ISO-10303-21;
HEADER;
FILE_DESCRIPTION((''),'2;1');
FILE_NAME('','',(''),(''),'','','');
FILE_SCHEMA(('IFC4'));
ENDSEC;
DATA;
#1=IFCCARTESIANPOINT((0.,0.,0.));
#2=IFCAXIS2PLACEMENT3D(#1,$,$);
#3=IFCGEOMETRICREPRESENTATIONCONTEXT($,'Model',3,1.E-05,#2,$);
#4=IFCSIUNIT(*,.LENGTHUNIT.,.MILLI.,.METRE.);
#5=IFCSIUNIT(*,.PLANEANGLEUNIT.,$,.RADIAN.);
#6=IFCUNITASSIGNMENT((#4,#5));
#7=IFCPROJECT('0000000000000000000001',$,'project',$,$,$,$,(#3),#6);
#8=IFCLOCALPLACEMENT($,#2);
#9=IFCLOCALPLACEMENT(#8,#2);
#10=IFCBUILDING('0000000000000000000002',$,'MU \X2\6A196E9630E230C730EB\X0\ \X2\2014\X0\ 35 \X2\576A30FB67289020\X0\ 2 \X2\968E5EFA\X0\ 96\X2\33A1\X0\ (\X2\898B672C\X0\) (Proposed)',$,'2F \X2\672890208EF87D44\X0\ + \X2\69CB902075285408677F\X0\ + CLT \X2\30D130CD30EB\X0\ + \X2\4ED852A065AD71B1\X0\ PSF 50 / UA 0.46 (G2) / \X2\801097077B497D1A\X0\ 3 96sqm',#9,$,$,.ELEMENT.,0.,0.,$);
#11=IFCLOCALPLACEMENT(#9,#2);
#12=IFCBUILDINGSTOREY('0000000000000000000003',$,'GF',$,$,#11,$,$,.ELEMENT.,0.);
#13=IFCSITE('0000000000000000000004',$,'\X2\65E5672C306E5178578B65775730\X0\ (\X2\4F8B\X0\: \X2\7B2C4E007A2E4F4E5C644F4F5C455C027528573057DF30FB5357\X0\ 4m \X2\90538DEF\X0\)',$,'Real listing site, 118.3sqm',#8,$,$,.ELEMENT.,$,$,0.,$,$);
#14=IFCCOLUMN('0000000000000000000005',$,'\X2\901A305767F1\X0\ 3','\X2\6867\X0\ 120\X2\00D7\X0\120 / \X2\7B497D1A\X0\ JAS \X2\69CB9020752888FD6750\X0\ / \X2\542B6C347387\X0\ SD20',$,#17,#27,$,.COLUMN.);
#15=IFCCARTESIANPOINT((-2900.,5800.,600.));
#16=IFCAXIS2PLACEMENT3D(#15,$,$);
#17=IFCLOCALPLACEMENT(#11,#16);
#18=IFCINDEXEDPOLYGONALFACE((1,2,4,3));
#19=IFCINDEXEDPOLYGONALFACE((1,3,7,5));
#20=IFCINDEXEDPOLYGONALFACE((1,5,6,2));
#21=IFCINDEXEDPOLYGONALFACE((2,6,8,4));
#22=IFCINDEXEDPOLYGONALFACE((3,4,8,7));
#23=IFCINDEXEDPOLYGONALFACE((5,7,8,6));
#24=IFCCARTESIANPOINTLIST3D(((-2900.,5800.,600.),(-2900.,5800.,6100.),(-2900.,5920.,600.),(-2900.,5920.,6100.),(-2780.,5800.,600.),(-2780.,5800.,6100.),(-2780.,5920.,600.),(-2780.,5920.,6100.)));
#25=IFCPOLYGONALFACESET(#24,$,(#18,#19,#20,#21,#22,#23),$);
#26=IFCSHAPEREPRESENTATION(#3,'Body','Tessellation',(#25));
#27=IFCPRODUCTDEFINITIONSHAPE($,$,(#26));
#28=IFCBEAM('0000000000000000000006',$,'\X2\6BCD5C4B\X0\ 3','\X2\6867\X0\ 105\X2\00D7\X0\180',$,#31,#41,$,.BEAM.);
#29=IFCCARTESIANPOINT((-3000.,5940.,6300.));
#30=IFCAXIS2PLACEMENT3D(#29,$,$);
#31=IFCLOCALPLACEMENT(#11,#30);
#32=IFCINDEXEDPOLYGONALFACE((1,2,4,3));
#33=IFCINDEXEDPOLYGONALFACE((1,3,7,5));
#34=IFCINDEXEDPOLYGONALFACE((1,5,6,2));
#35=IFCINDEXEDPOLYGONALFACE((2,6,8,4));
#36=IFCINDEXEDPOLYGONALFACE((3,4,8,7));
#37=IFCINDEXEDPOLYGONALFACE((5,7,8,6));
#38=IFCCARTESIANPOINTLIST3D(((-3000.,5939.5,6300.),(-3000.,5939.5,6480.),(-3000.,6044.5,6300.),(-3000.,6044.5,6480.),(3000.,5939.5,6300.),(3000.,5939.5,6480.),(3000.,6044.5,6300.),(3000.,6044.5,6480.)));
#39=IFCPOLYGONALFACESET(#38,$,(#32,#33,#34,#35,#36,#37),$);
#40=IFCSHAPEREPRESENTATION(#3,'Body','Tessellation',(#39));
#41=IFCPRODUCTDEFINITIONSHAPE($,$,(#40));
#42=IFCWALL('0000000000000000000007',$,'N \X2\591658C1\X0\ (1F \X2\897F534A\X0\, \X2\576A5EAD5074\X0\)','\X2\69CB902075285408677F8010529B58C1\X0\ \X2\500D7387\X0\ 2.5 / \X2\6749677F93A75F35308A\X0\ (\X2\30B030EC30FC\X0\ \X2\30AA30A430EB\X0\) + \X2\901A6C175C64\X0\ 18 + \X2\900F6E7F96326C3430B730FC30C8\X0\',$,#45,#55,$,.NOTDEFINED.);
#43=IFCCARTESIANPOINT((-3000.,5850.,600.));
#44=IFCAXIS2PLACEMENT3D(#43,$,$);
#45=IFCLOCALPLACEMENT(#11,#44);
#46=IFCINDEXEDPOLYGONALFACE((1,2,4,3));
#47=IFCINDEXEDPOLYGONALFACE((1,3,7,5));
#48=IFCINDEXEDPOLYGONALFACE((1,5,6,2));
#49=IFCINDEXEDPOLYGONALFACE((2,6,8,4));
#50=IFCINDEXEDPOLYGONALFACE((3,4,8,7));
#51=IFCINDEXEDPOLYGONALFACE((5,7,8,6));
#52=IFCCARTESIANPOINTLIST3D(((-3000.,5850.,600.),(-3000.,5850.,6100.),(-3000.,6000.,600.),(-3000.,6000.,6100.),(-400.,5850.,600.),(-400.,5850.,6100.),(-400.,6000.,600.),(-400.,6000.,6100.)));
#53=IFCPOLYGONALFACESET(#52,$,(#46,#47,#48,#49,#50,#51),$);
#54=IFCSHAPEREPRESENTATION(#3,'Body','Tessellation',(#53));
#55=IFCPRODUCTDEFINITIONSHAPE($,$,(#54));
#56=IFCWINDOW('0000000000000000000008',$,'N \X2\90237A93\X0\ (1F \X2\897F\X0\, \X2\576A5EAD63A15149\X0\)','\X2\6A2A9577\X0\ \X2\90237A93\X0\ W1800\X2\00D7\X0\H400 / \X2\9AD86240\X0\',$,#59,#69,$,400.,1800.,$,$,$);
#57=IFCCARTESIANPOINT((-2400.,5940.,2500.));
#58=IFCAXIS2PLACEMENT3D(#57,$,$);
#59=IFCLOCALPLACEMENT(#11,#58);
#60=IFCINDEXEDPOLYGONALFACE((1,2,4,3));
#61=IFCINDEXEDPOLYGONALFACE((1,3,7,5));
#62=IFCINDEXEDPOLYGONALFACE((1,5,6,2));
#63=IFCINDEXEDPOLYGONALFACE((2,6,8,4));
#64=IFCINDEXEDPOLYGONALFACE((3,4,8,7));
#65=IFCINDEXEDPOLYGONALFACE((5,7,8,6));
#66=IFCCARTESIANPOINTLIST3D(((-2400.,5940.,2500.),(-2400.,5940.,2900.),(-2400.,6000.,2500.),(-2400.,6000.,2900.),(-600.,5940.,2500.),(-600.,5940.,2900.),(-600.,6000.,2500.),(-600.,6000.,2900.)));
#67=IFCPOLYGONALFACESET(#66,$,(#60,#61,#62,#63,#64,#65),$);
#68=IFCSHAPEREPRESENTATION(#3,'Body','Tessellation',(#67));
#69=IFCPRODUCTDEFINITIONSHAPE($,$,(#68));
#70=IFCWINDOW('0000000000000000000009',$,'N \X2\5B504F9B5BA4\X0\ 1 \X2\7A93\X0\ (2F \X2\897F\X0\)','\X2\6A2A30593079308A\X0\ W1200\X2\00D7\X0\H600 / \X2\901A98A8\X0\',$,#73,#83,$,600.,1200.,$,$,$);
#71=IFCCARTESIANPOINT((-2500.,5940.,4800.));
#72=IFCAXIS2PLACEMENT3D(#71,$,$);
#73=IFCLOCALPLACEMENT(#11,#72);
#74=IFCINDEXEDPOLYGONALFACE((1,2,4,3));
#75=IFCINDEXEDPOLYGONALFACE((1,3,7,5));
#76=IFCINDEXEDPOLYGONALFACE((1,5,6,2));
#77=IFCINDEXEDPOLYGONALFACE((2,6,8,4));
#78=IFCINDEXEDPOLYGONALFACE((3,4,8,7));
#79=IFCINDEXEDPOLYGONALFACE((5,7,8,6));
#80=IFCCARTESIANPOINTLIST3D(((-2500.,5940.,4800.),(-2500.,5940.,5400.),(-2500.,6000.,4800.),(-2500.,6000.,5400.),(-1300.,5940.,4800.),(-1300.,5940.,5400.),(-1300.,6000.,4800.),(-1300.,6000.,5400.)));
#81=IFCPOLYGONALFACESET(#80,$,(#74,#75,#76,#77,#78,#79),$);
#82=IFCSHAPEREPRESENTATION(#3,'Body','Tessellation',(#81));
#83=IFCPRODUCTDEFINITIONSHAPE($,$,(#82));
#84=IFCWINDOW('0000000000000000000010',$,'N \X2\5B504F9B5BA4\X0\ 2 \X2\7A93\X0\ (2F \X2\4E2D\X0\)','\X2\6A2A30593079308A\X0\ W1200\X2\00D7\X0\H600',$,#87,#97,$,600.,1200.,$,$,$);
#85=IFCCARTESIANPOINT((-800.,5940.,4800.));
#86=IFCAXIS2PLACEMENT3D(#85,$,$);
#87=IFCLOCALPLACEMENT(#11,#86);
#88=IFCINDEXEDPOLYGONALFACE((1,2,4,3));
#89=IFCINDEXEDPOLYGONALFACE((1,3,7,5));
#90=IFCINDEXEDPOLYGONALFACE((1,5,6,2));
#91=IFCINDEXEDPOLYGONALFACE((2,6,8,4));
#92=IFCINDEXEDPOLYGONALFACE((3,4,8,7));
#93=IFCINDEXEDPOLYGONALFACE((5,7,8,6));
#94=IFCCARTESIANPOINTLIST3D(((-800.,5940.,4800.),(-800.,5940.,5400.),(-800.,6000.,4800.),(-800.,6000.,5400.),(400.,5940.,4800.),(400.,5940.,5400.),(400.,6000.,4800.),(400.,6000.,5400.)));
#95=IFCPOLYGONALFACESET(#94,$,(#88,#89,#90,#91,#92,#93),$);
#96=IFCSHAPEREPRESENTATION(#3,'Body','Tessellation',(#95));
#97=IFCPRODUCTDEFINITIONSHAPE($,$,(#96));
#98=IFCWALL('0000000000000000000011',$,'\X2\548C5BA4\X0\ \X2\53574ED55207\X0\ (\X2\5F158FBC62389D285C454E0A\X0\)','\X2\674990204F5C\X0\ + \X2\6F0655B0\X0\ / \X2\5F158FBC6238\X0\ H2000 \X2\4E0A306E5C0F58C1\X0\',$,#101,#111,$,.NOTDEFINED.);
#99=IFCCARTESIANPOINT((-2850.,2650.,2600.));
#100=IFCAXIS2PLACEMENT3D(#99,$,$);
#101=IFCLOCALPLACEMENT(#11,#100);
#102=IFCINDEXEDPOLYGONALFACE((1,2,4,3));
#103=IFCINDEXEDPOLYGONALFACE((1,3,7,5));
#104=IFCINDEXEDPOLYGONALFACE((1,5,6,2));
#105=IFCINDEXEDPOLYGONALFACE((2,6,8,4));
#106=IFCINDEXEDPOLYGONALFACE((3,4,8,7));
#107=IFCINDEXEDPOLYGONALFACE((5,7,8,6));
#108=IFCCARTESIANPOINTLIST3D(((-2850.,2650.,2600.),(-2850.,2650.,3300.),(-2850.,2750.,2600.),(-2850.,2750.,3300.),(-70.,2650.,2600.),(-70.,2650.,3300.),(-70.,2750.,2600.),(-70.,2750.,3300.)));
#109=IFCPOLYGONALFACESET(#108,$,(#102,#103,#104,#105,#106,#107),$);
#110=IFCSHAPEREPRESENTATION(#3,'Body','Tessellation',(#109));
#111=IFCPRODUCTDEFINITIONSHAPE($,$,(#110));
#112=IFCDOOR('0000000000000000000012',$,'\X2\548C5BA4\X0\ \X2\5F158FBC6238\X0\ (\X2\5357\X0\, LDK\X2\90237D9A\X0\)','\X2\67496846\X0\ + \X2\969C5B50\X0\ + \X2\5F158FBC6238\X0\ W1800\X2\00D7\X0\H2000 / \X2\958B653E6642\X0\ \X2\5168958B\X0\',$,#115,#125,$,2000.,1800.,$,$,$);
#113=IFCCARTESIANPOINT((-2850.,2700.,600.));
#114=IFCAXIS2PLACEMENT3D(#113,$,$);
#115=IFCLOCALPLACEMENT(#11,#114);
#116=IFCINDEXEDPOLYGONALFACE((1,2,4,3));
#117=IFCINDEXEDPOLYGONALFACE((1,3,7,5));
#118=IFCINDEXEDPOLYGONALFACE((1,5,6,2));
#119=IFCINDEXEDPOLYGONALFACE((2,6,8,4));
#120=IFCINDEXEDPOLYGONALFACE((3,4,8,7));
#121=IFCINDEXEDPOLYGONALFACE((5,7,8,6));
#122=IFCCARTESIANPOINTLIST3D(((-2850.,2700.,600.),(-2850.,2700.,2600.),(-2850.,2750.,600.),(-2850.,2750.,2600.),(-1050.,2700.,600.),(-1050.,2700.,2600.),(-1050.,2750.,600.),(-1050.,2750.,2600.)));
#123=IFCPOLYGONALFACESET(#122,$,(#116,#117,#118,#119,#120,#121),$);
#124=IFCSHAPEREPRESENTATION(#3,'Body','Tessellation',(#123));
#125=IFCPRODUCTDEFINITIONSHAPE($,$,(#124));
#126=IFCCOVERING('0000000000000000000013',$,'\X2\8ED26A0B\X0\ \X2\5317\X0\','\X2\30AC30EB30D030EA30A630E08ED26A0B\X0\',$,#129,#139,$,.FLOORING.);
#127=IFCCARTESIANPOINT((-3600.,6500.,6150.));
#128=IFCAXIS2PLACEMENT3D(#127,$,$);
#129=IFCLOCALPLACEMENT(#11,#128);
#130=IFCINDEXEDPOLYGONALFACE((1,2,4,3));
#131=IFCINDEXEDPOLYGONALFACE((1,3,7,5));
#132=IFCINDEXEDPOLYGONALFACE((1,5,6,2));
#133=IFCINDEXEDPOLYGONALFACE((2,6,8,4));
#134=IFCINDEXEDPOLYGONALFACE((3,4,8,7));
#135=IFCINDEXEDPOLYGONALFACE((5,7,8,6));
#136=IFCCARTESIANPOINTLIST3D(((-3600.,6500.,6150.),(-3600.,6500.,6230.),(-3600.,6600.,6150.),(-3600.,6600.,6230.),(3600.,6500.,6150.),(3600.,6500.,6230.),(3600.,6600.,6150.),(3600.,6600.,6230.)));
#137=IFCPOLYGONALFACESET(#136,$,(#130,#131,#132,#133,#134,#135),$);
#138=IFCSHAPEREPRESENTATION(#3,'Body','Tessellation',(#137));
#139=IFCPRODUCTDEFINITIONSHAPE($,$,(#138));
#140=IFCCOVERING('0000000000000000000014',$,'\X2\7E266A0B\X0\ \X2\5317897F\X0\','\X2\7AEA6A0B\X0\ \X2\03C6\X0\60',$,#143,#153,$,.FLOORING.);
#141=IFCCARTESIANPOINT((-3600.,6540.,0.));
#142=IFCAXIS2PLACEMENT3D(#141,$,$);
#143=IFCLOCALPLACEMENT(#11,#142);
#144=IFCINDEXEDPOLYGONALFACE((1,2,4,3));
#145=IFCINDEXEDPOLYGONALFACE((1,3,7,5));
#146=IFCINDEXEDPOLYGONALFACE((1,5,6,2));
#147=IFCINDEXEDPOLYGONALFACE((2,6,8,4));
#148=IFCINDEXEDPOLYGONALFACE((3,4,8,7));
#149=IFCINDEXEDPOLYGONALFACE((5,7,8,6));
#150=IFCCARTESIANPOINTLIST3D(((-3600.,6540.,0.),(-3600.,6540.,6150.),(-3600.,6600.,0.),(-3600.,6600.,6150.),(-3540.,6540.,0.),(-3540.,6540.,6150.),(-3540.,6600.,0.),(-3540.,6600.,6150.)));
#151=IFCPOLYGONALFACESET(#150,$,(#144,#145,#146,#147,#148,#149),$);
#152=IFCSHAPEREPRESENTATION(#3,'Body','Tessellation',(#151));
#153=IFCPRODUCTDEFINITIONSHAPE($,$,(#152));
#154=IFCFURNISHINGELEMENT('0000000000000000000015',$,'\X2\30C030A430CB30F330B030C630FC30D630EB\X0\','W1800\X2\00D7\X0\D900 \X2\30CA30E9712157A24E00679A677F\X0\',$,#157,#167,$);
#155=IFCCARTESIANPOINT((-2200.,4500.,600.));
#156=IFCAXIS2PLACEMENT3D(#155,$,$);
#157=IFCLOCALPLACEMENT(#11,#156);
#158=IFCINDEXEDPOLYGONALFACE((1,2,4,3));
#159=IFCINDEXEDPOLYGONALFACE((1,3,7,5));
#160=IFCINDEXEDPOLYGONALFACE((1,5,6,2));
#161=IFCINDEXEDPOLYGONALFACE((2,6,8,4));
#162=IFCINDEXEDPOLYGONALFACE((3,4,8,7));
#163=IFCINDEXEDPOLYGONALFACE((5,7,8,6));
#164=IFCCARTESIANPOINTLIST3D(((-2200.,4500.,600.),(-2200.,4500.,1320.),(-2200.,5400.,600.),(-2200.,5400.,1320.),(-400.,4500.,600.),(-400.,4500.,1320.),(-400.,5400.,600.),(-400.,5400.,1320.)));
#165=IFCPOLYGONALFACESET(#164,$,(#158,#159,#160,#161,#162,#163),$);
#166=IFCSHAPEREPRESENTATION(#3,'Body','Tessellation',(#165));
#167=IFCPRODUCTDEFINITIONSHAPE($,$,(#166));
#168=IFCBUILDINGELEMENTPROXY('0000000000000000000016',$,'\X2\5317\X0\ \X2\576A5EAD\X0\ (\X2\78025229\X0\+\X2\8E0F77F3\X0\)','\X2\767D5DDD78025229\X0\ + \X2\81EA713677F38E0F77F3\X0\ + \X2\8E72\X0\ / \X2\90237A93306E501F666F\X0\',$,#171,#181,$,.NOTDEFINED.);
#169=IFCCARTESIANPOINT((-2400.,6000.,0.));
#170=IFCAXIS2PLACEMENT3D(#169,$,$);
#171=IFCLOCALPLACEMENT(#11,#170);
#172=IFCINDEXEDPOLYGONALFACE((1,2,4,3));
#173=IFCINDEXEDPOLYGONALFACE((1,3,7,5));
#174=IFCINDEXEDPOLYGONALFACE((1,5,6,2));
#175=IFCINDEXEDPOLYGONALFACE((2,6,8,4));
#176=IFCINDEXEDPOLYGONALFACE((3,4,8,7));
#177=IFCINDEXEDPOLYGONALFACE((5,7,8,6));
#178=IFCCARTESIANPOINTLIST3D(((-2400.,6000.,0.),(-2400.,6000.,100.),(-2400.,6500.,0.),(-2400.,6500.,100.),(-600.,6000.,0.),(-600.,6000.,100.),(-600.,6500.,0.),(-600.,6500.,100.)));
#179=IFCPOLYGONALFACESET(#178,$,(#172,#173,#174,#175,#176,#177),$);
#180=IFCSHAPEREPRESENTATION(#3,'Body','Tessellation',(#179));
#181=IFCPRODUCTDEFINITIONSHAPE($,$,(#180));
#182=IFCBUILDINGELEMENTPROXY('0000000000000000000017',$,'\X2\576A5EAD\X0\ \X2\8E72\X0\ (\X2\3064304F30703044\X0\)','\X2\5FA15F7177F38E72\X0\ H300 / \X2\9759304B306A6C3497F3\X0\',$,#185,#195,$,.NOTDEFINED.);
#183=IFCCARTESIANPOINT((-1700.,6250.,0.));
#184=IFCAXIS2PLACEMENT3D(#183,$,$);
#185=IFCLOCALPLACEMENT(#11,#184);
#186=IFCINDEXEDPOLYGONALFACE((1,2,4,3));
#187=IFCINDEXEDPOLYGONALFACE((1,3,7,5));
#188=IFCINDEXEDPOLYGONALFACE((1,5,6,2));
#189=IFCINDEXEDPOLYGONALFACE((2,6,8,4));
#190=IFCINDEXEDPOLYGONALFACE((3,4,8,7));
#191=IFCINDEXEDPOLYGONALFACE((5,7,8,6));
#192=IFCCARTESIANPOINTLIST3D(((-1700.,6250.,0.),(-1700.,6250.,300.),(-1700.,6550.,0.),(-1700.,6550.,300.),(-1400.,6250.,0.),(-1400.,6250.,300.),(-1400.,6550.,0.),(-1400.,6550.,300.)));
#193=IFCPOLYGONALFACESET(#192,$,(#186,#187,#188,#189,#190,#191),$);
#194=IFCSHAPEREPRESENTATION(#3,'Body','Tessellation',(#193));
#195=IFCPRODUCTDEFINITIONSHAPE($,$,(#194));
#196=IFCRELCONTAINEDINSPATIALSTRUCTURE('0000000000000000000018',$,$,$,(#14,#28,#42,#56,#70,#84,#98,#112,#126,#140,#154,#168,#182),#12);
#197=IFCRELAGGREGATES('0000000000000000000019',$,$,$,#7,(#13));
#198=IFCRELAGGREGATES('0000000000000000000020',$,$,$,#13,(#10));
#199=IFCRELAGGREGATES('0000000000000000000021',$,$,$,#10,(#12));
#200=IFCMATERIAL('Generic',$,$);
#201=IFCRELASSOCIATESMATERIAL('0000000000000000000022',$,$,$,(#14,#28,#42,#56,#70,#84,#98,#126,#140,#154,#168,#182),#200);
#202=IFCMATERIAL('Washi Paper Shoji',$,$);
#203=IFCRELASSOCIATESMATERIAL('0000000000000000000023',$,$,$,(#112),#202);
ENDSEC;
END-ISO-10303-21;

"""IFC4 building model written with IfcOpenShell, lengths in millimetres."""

from ifc_helpers import new_model, si_unit, frame, frame_2d, origin, place, context, project, spatial, rectangle, extrude, material, element, fill, save


model = new_model("IFC4")

# Units and contexts
model_context = context("Model", 3, precision=1e-05, world=origin())
ifc_project = project(units=[si_unit("LENGTHUNIT", "METRE", prefix="MILLI"), si_unit("PLANEANGLEUNIT", "RADIAN")], contexts=[model_context])

# Site, building, storey
site_placement = place(None, origin())
site = spatial("IfcSite", under=ifc_project, at=site_placement, Name="日本の典型敷地 (例: 第一種低層住居専用地域・南 4m 道路)", ObjectType="Real listing site, 118.3sqm", CompositionType="ELEMENT", RefElevation=0.0)
building_placement = place(site_placement, origin())
building = spatial("IfcBuilding", under=site, at=building_placement, Name="MU 標準モデル — 35 坪・木造 2 階建 96㎡ (見本) (Proposed)", ObjectType="2F 木造軸組 + 構造用合板 + CLT パネル + 付加断熱 PSF 50 / UA 0.46 (G2) / 耐震等級 3 96sqm", CompositionType="ELEMENT", ElevationOfRefHeight=0.0, ElevationOfTerrain=0.0)
storey_placement = place(building_placement, origin())
storey = spatial("IfcBuildingStorey", under=building, at=storey_placement, Name="GF", CompositionType="ELEMENT", Elevation=0.0)

# Column
ifc_material_1 = material(Name="Generic")
column_placement = place(storey_placement, frame((-2900.0, 5800.0, 600.0)))
element("IfcColumn", 1, at=column_placement, inside=storey, material=ifc_material_1, Name="通し柱 3", Description="桧 120×120 / 等級 JAS 構造用製材 / 含水率 SD20", PredefinedType="COLUMN", context=model_context, shape_type="SweptSolid", body=[
    extrude(rectangle(XDim=120.0, YDim=120.0, at=frame_2d((60.0, 60.0))), frame((-2900.0, 5800.0, 600.0)), (0.0, 0.0, 1.0), 5500.0),
])

# Beam
beam_placement = place(storey_placement, frame((-3000.0, 5940.0, 6300.0)))
element("IfcBeam", 2, at=beam_placement, inside=storey, material=ifc_material_1, Name="母屋 3", Description="桧 105×180", PredefinedType="BEAM", context=model_context, shape_type="SweptSolid", body=[
    extrude(rectangle(XDim=6000.0, YDim=105.0, at=frame_2d((3000.0, 52.0))), frame((-3000.0, 5940.0, 6300.0)), (0.0, 0.0, 1.0), 180.0),
])

# Wall, openings, windows
wall_1_placement = place(storey_placement, frame((-3000.0, 5850.0, 600.0)))
wall_1 = element("IfcWall", 3, at=wall_1_placement, inside=storey, material=ifc_material_1, Name="N 外壁 (1F 西半, 坪庭側)", Description="構造用合板耐力壁 倍率 2.5 / 杉板鎧張り (グレー オイル) + 通気層 18 + 透湿防水シート", PredefinedType="NOTDEFINED", context=model_context, shape_type="SweptSolid", body=[
    extrude(rectangle(XDim=2600.0, YDim=150.0, at=frame_2d((1300.0, 75.0))), frame((-3000.0, 5850.0, 600.0)), (0.0, 0.0, 1.0), 5500.0),
])
opening_1_placement = place(storey_placement, frame((-2400.0, 5940.0, 2500.0)))
opening_1 = element("IfcOpeningElement", 4, at=opening_1_placement, cuts=wall_1, PredefinedType="NOTDEFINED", context=model_context, shape_type="SweptSolid", body=[
    extrude(rectangle(XDim=1800.0, YDim=60.0, at=frame_2d((900.0, 30.0))), frame((-2400.0, 5940.0, 2500.0)), (0.0, 0.0, 1.0), 400.0),
])
opening_2_placement = place(storey_placement, frame((-2500.0, 5940.0, 4800.0)))
opening_2 = element("IfcOpeningElement", 5, at=opening_2_placement, cuts=wall_1, PredefinedType="NOTDEFINED", context=model_context, shape_type="SweptSolid", body=[
    extrude(rectangle(XDim=1200.0, YDim=60.0, at=frame_2d((600.0, 30.0))), frame((-2500.0, 5940.0, 4800.0)), (0.0, 0.0, 1.0), 600.0),
])
opening_3_placement = place(storey_placement, frame((-800.0, 5940.0, 4800.0)))
opening_3 = element("IfcOpeningElement", 6, at=opening_3_placement, cuts=wall_1, PredefinedType="NOTDEFINED", context=model_context, shape_type="SweptSolid", body=[
    extrude(rectangle(XDim=1200.0, YDim=60.0, at=frame_2d((600.0, 30.0))), frame((-800.0, 5940.0, 4800.0)), (0.0, 0.0, 1.0), 600.0),
])
window_1_placement = place(storey_placement, frame((-2400.0, 5940.0, 2500.0)))
window_1 = element("IfcWindow", 7, at=window_1_placement, inside=storey, material=ifc_material_1, Name="N 連窓 (1F 西, 坪庭採光)", Description="横長 連窓 W1800×H400 / 高所", OverallHeight=400.0, OverallWidth=1800.0, context=model_context, shape_type="SweptSolid", body=[
    extrude(rectangle(XDim=1800.0, YDim=60.0, at=frame_2d((900.0, 30.0))), frame((-2400.0, 5940.0, 2500.0)), (0.0, 0.0, 1.0), 400.0),
])
fill(opening_1, window_1)
window_2_placement = place(storey_placement, frame((-2500.0, 5940.0, 4800.0)))
window_2 = element("IfcWindow", 8, at=window_2_placement, inside=storey, material=ifc_material_1, Name="N 子供室 1 窓 (2F 西)", Description="横すべり W1200×H600 / 通風", OverallHeight=600.0, OverallWidth=1200.0, context=model_context, shape_type="SweptSolid", body=[
    extrude(rectangle(XDim=1200.0, YDim=60.0, at=frame_2d((600.0, 30.0))), frame((-2500.0, 5940.0, 4800.0)), (0.0, 0.0, 1.0), 600.0),
])
fill(opening_2, window_2)
window_3_placement = place(storey_placement, frame((-800.0, 5940.0, 4800.0)))
window_3 = element("IfcWindow", 9, at=window_3_placement, inside=storey, material=ifc_material_1, Name="N 子供室 2 窓 (2F 中)", Description="横すべり W1200×H600", OverallHeight=600.0, OverallWidth=1200.0, context=model_context, shape_type="SweptSolid", body=[
    extrude(rectangle(XDim=1200.0, YDim=60.0, at=frame_2d((600.0, 30.0))), frame((-800.0, 5940.0, 4800.0)), (0.0, 0.0, 1.0), 600.0),
])
fill(opening_3, window_3)

# Wall
wall_2_placement = place(storey_placement, frame((-2850.0, 2650.0, 2600.0)))
element("IfcWall", 10, at=wall_2_placement, inside=storey, material=ifc_material_1, Name="和室 南仕切 (引込戸鴨居上)", Description="杉造作 + 漆喰 / 引込戸 H2000 上の小壁", PredefinedType="NOTDEFINED", context=model_context, shape_type="SweptSolid", body=[
    extrude(rectangle(XDim=2780.0, YDim=100.0, at=frame_2d((1390.0, 50.0))), frame((-2850.0, 2650.0, 2600.0)), (0.0, 0.0, 1.0), 700.0),
])

# Door
ifc_material_2 = material(Name="Washi Paper Shoji")
door_placement = place(storey_placement, frame((-2850.0, 2700.0, 600.0)))
element("IfcDoor", 11, at=door_placement, inside=storey, material=ifc_material_2, Name="和室 引込戸 (南, LDK連続)", Description="杉框 + 障子 + 引込戸 W1800×H2000 / 開放時 全開", OverallHeight=2000.0, OverallWidth=1800.0, context=model_context, shape_type="SweptSolid", body=[
    extrude(rectangle(XDim=1800.0, YDim=50.0, at=frame_2d((900.0, 25.0))), frame((-2850.0, 2700.0, 600.0)), (0.0, 0.0, 1.0), 2000.0),
])

# Coverings
covering_1_placement = place(storey_placement, frame((-3600.0, 6500.0, 6150.0)))
element("IfcCovering", 12, at=covering_1_placement, inside=storey, material=ifc_material_1, Name="軒樋 北", Description="ガルバリウム軒樋", PredefinedType="FLOORING", context=model_context, shape_type="SweptSolid", body=[
    extrude(rectangle(XDim=7200.0, YDim=100.0, at=frame_2d((3600.0, 50.0))), frame((-3600.0, 6500.0, 6150.0)), (0.0, 0.0, 1.0), 80.0),
])
covering_2_placement = place(storey_placement, frame((-3600.0, 6540.0, 0.0)))
element("IfcCovering", 13, at=covering_2_placement, inside=storey, material=ifc_material_1, Name="縦樋 北西", Description="竪樋 φ60", PredefinedType="FLOORING", context=model_context, shape_type="SweptSolid", body=[
    extrude(rectangle(XDim=60.0, YDim=60.0, at=frame_2d((30.0, 30.0))), frame((-3600.0, 6540.0, 0.0)), (0.0, 0.0, 1.0), 6150.0),
])

# Furnishing element
furnishing_placement = place(storey_placement, frame((-2200.0, 4500.0, 600.0)))
element("IfcFurnishingElement", 14, at=furnishing_placement, inside=storey, material=ifc_material_1, Name="ダイニングテーブル", Description="W1800×D900 ナラ無垢一枚板", context=model_context, shape_type="SweptSolid", body=[
    extrude(rectangle(XDim=1800.0, YDim=900.0, at=frame_2d((900.0, 450.0))), frame((-2200.0, 4500.0, 600.0)), (0.0, 0.0, 1.0), 720.0),
])

# Building element proxies
proxy_1_placement = place(storey_placement, frame((-2400.0, 6000.0, 0.0)))
element("IfcBuildingElementProxy", 15, at=proxy_1_placement, inside=storey, material=ifc_material_1, Name="北 坪庭 (砂利+踏石)", Description="白川砂利 + 自然石踏石 + 蹲 / 連窓の借景", PredefinedType="NOTDEFINED", context=model_context, shape_type="SweptSolid", body=[
    extrude(rectangle(XDim=1800.0, YDim=500.0, at=frame_2d((900.0, 250.0))), frame((-2400.0, 6000.0, 0.0)), (0.0, 0.0, 1.0), 100.0),
])
proxy_2_placement = place(storey_placement, frame((-1700.0, 6250.0, 0.0)))
element("IfcBuildingElementProxy", 16, at=proxy_2_placement, inside=storey, material=ifc_material_1, Name="坪庭 蹲 (つくばい)", Description="御影石蹲 H300 / 静かな水音", PredefinedType="NOTDEFINED", context=model_context, shape_type="SweptSolid", body=[
    extrude(rectangle(XDim=300.0, YDim=300.0, at=frame_2d((150.0, 150.0))), frame((-1700.0, 6250.0, 0.0)), (0.0, 0.0, 1.0), 300.0),
])

save(model, "model.ifc")
